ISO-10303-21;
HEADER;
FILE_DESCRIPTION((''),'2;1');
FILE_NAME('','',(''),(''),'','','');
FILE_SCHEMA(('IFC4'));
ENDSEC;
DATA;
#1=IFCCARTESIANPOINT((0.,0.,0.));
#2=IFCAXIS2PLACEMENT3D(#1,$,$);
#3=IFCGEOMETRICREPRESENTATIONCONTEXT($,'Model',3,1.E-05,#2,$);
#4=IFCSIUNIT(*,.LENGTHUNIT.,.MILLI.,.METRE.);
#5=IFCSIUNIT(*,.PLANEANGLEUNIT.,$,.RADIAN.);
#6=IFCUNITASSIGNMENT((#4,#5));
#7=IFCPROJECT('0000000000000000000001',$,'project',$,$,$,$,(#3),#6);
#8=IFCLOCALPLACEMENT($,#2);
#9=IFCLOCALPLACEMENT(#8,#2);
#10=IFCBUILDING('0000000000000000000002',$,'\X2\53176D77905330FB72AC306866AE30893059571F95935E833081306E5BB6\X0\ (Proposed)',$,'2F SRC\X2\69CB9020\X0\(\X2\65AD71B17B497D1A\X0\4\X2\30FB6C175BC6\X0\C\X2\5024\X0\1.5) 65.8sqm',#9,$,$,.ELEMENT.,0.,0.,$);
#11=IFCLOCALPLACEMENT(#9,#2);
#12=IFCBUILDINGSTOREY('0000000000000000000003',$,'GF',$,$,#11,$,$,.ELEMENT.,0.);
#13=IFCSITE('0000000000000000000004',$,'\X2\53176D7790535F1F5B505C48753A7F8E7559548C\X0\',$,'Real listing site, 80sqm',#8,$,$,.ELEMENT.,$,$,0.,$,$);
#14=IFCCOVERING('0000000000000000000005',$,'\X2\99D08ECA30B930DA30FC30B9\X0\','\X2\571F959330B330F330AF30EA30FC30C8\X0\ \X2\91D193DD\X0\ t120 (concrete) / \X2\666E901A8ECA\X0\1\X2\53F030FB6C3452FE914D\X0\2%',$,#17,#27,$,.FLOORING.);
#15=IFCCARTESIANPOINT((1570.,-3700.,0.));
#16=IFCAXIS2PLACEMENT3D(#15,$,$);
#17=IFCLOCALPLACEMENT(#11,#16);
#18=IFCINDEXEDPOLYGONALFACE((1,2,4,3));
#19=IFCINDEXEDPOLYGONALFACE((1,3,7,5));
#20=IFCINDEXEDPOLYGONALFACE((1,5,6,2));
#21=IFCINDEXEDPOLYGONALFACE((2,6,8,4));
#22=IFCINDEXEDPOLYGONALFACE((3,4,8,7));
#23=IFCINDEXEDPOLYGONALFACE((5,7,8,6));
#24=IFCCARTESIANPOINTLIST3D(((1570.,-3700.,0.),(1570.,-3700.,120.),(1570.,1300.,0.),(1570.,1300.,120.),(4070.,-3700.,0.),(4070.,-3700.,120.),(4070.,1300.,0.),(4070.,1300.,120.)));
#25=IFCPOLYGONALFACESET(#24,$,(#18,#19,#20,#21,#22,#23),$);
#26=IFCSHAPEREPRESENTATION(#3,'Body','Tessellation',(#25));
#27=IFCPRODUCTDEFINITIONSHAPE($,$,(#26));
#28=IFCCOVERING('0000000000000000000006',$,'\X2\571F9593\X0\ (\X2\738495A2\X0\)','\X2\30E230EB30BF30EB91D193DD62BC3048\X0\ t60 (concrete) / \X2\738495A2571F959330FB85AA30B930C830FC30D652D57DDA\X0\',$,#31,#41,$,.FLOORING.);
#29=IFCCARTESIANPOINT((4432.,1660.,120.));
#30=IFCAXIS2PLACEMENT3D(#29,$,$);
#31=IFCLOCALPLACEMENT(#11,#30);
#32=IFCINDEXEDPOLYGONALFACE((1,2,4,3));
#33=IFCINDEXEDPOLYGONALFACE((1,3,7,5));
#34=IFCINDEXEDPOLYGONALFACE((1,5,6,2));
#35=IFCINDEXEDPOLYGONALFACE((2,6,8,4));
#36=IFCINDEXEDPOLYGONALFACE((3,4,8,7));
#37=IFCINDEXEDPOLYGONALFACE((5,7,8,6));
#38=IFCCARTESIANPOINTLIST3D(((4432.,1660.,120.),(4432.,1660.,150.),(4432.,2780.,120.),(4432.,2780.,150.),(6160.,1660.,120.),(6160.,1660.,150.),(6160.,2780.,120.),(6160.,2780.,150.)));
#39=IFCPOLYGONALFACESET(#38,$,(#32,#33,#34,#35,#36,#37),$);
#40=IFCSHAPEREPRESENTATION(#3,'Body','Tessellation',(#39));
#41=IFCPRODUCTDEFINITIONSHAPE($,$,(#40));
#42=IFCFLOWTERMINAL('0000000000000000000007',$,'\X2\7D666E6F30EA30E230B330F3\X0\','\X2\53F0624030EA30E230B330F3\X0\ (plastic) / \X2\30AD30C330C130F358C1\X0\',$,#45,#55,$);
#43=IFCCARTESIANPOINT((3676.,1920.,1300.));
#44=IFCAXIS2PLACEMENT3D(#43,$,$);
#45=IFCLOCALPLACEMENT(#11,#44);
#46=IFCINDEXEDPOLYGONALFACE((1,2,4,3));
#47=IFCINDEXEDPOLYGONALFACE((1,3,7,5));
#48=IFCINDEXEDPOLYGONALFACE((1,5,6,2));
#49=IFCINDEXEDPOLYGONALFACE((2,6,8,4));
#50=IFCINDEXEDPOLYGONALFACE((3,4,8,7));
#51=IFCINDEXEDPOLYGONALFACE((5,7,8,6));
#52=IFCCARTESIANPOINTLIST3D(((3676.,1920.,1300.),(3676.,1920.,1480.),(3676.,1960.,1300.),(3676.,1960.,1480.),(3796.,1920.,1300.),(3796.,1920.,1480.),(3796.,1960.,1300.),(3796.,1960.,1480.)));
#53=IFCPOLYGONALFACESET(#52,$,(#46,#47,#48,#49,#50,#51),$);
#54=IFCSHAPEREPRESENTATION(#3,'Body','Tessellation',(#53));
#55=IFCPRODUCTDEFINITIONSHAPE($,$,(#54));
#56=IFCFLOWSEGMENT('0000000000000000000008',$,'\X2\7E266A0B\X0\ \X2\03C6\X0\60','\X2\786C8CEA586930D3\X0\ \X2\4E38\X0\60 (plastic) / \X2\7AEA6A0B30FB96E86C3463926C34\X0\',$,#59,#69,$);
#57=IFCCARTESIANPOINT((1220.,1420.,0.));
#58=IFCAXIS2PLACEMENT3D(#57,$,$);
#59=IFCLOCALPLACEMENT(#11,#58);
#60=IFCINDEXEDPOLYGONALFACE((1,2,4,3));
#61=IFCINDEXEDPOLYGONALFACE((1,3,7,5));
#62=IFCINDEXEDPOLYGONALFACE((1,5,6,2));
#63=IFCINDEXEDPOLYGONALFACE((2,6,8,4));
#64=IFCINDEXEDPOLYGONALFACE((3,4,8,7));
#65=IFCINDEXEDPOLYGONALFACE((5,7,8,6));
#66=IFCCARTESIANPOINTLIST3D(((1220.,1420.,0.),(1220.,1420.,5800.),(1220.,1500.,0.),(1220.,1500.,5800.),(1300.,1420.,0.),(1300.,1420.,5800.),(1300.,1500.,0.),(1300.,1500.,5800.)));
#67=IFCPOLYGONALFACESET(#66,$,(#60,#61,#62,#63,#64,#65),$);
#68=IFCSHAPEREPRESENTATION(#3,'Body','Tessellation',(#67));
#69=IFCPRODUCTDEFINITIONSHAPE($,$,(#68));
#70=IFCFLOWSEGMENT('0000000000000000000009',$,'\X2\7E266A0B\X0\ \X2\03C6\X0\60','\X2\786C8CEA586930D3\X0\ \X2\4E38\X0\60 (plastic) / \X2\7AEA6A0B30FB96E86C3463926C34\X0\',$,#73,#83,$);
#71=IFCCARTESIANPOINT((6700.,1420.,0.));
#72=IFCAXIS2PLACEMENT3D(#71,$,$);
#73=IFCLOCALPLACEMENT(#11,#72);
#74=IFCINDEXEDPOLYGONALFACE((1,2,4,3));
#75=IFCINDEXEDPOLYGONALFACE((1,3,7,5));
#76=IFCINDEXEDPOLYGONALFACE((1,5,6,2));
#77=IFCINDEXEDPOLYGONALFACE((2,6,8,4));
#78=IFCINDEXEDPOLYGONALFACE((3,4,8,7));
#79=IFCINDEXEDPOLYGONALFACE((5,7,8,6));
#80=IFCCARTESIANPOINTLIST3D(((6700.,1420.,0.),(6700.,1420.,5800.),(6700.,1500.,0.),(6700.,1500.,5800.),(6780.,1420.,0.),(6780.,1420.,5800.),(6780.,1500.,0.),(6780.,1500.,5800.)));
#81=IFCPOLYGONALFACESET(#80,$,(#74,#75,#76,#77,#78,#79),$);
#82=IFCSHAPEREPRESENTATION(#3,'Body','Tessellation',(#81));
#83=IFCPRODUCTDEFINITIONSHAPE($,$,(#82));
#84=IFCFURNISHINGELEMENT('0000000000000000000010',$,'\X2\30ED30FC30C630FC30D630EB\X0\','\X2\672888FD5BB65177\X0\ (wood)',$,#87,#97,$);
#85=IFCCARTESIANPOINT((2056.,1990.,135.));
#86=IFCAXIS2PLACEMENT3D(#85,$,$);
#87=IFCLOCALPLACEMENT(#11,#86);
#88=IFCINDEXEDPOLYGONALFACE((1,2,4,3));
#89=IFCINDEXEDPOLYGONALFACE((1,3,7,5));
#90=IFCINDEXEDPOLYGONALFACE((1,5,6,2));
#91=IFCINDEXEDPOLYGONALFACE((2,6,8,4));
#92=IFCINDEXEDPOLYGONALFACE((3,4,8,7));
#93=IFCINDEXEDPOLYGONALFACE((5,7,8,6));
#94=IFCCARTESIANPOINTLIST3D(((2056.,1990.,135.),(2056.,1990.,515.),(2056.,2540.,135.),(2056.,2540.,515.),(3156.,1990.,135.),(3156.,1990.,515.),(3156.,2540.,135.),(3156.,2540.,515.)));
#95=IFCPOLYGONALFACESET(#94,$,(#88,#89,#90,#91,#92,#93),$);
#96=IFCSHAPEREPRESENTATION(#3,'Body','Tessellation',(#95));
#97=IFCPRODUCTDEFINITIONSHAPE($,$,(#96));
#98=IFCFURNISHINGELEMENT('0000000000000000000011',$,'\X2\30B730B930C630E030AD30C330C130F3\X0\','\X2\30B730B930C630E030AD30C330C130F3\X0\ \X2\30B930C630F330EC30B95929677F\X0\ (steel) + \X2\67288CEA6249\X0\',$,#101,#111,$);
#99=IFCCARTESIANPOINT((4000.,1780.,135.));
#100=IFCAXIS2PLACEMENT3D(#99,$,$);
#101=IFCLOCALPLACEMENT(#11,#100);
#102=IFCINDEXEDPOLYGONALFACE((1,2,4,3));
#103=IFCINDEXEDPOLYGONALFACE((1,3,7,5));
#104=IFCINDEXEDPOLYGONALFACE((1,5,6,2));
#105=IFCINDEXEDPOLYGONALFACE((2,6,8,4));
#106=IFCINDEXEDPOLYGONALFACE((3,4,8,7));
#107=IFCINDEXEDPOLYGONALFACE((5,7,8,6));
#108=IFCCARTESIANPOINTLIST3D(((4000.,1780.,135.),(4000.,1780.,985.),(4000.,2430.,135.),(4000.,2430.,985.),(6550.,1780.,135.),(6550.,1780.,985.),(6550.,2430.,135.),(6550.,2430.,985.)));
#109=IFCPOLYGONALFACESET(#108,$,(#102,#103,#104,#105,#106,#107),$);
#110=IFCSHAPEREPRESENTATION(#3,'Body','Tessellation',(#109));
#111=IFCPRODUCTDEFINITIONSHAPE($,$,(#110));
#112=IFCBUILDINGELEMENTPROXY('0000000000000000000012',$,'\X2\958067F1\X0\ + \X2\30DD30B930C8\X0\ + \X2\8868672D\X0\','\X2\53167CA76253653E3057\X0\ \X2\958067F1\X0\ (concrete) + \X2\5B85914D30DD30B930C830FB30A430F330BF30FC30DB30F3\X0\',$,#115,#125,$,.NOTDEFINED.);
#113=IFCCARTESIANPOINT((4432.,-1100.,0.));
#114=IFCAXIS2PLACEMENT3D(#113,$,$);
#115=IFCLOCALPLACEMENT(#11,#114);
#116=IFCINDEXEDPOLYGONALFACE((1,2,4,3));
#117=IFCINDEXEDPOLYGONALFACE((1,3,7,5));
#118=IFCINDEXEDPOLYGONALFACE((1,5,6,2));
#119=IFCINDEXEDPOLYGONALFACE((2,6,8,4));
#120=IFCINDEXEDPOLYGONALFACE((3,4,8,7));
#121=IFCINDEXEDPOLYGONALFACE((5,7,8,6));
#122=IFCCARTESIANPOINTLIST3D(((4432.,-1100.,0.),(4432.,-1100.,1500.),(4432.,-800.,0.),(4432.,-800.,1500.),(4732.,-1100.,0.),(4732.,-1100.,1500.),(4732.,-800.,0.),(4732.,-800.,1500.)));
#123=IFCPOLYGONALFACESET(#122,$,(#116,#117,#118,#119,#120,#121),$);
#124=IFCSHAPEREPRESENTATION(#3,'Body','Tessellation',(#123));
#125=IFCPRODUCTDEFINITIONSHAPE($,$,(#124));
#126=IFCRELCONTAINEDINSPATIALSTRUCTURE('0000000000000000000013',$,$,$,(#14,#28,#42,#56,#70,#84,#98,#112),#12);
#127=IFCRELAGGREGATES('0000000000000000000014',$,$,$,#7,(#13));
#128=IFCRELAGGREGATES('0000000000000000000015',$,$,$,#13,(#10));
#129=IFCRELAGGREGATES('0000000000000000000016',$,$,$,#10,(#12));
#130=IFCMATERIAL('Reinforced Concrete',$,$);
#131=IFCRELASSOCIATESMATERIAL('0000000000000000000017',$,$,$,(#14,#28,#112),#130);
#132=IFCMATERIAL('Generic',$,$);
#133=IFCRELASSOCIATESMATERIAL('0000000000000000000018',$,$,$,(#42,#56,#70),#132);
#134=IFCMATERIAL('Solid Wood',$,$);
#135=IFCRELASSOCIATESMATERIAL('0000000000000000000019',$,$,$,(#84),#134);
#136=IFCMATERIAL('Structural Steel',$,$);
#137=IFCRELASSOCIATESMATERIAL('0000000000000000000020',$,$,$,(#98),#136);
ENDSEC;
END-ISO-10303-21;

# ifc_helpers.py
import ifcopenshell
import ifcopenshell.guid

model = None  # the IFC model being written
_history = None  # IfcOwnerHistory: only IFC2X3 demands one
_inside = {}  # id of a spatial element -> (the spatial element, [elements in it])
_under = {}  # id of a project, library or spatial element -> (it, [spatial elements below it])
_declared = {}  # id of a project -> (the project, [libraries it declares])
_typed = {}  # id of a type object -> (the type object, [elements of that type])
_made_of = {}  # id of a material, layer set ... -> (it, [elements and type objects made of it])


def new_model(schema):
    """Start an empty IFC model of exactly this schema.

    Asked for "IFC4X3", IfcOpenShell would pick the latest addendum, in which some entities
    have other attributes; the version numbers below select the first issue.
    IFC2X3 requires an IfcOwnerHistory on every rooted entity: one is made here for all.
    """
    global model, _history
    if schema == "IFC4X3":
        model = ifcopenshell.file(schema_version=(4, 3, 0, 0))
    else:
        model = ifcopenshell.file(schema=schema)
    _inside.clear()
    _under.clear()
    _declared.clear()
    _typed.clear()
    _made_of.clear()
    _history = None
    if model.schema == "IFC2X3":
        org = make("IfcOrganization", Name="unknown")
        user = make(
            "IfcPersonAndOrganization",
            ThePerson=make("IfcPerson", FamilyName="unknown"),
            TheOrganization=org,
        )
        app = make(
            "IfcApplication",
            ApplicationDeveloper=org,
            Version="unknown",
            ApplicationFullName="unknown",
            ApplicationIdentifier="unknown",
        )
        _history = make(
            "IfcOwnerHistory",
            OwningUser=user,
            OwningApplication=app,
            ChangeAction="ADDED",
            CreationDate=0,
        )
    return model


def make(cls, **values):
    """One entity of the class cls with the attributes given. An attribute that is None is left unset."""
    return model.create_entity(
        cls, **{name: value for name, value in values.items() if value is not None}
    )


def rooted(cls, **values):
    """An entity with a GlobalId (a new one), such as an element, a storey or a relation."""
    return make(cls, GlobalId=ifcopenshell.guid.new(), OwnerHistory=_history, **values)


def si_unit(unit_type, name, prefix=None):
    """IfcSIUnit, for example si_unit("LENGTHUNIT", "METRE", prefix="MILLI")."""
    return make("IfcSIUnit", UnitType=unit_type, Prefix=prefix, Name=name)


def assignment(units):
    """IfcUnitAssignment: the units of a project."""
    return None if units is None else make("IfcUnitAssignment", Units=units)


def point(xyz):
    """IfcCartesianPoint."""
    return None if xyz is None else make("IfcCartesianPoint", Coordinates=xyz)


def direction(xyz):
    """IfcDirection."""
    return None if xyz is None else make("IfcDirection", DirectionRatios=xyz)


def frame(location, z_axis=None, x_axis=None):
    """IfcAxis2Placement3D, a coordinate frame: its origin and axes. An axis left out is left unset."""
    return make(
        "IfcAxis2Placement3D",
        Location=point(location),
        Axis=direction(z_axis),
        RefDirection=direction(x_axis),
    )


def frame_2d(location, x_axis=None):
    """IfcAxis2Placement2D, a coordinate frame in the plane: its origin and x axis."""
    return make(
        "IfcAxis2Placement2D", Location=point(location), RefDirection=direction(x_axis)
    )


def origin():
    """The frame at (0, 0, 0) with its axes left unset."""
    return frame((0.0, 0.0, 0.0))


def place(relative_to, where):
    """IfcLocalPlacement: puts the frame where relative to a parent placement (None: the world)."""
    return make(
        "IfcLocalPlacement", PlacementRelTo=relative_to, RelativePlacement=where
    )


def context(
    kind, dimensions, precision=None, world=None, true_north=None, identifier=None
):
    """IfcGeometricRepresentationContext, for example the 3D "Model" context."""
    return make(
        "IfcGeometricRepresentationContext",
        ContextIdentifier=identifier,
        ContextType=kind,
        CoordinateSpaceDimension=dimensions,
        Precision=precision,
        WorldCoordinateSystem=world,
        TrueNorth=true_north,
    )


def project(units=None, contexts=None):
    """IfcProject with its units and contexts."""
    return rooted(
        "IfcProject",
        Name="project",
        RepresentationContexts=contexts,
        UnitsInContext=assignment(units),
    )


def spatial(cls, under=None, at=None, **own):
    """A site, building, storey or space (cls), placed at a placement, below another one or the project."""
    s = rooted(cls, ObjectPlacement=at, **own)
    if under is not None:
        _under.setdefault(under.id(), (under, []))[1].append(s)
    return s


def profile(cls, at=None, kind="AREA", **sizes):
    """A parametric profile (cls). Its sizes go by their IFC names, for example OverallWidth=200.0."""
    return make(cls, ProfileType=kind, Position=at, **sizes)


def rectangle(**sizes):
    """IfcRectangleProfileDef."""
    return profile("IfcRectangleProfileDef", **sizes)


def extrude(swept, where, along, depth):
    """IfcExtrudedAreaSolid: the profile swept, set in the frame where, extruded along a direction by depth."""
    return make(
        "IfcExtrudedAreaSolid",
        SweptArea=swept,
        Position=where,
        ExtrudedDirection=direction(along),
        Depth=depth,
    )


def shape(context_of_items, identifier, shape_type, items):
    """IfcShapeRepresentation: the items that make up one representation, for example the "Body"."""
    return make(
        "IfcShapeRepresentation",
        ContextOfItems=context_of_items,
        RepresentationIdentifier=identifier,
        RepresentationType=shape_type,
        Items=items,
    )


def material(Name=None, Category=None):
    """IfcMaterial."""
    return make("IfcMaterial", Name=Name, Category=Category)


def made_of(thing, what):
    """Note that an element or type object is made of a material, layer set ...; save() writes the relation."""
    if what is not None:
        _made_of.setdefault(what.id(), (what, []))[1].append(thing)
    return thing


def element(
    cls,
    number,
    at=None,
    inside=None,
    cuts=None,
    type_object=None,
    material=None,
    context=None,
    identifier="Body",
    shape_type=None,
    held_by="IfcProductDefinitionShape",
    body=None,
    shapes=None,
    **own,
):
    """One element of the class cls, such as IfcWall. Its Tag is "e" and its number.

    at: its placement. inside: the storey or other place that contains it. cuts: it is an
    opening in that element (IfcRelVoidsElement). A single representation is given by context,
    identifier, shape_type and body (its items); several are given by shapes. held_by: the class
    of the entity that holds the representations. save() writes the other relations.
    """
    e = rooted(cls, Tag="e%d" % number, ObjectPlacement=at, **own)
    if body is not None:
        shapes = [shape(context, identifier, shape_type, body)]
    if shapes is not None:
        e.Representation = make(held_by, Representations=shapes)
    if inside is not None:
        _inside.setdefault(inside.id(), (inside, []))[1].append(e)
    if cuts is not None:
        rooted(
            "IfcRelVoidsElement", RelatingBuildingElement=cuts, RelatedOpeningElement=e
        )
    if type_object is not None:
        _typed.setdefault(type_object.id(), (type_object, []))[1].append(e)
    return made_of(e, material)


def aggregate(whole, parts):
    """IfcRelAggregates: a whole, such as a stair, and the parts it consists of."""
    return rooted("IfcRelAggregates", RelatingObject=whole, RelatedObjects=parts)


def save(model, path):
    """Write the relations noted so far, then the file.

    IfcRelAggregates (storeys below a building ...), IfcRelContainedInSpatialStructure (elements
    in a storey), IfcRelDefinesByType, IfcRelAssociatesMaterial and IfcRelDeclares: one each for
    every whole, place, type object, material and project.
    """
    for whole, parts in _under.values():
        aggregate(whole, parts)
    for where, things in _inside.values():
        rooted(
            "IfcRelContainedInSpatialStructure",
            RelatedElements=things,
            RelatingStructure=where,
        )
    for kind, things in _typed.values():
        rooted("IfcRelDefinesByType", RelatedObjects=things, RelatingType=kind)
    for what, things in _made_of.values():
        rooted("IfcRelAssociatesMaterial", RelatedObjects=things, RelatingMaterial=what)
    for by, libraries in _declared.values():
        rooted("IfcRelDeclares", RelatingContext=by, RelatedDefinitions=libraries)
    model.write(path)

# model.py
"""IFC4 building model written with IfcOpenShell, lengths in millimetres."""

from ifc_helpers import new_model, si_unit, frame, frame_2d, origin, place, context, project, spatial, rectangle, extrude, material, element, save


model = new_model("IFC4")

# Units and contexts
model_context = context("Model", 3, precision=1e-05, world=origin())
ifc_project = project(units=[si_unit("LENGTHUNIT", "METRE", prefix="MILLI"), si_unit("PLANEANGLEUNIT", "RADIAN")], contexts=[model_context])

# Site, building, storey
site_placement = place(None, origin())
site = spatial("IfcSite", under=ifc_project, at=site_placement, Name="北海道弟子屈町美留和", ObjectType="Real listing site, 80sqm", CompositionType="ELEMENT", RefElevation=0.0)
building_placement = place(site_placement, origin())
building = spatial("IfcBuilding", under=site, at=building_placement, Name="北海道・犬と暮らす土間広めの家 (Proposed)", ObjectType="2F SRC構造(断熱等級4・気密C値1.5) 65.8sqm", CompositionType="ELEMENT", ElevationOfRefHeight=0.0, ElevationOfTerrain=0.0)
storey_placement = place(building_placement, origin())
storey = spatial("IfcBuildingStorey", under=building, at=storey_placement, Name="GF", CompositionType="ELEMENT", Elevation=0.0)

# Shared definitions
ifc_material_1 = material(Name="Solid Wood")

# Shared definitions
ifc_material_2 = material(Name="Reinforced Concrete")

# Coverings
ifc_material_3 = material(Name="Generic")
covering_1_placement = place(storey_placement, frame((1570.0, -3700.0, 0.0)))
element("IfcCovering", 1, at=covering_1_placement, inside=storey, material=ifc_material_2, Name="駐車スペース", Description="土間コンクリート 金鏝 t120 (concrete) / 普通車1台・水勾配2%", PredefinedType="FLOORING", context=model_context, shape_type="SweptSolid", body=[
    extrude(rectangle(XDim=2500.0, YDim=5000.0, at=frame_2d((1250.0, 2500.0))), frame((1570.0, -3700.0, 0.0)), (0.0, 0.0, 1.0), 120.0),
])
covering_2_placement = place(storey_placement, frame((4432.0, 1660.0, 120.0)))
element("IfcCovering", 2, at=covering_2_placement, inside=storey, material=ifc_material_2, Name="土間 (玄関)", Description="モルタル金鏝押え t60 (concrete) / 玄関土間・薪ストーブ動線", PredefinedType="FLOORING", context=model_context, shape_type="SweptSolid", body=[
    extrude(rectangle(XDim=1728.0, YDim=1120.0, at=frame_2d((864.0, 560.0))), frame((4432.0, 1660.0, 120.0)), (0.0, 0.0, 1.0), 30.0),
])

# Flow terminal
flow_terminal_placement = place(storey_placement, frame((3676.0, 1920.0, 1300.0)))
element("IfcFlowTerminal", 3, at=flow_terminal_placement, inside=storey, material=ifc_material_3, Name="給湯リモコン", Description="台所リモコン (plastic) / キッチン壁", context=model_context, shape_type="SweptSolid", body=[
    extrude(rectangle(XDim=120.0, YDim=40.0, at=frame_2d((60.0, 20.0))), frame((3676.0, 1920.0, 1300.0)), (0.0, 0.0, 1.0), 180.0),
])

# Flow segments
flow_segment_1_placement = place(storey_placement, frame((1220.0, 1420.0, 0.0)))
element("IfcFlowSegment", 4, at=flow_segment_1_placement, inside=storey, material=ifc_material_3, Name="縦樋 φ60", Description="硬質塩ビ 丸60 (plastic) / 竪樋・雨水排水", context=model_context, shape_type="SweptSolid", body=[
    extrude(rectangle(XDim=80.0, YDim=80.0, at=frame_2d((40.0, 40.0))), frame((1220.0, 1420.0, 0.0)), (0.0, 0.0, 1.0), 5800.0),
])
flow_segment_2_placement = place(storey_placement, frame((6700.0, 1420.0, 0.0)))
element("IfcFlowSegment", 5, at=flow_segment_2_placement, inside=storey, material=ifc_material_3, Name="縦樋 φ60", Description="硬質塩ビ 丸60 (plastic) / 竪樋・雨水排水", context=model_context, shape_type="SweptSolid", body=[
    extrude(rectangle(XDim=80.0, YDim=80.0, at=frame_2d((40.0, 40.0))), frame((6700.0, 1420.0, 0.0)), (0.0, 0.0, 1.0), 5800.0),
])

# Furnishing elements
furnishing_1_placement = place(storey_placement, frame((2056.0, 1990.0, 135.0)))
element("IfcFurnishingElement", 6, at=furnishing_1_placement, inside=storey, material=ifc_material_1, Name="ローテーブル", Description="木製家具 (wood)", context=model_context, shape_type="SweptSolid", body=[
    extrude(rectangle(XDim=1100.0, YDim=550.0, at=frame_2d((550.0, 275.0))), frame((2056.0, 1990.0, 135.0)), (0.0, 0.0, 1.0), 380.0),
])
ifc_material_4 = material(Name="Structural Steel")
furnishing_2_placement = place(storey_placement, frame((4000.0, 1780.0, 135.0)))
element("IfcFurnishingElement", 7, at=furnishing_2_placement, inside=storey, material=ifc_material_4, Name="システムキッチン", Description="システムキッチン ステンレス天板 (steel) + 木質扉", context=model_context, shape_type="SweptSolid", body=[
    extrude(rectangle(XDim=2550.0, YDim=650.0, at=frame_2d((1275.0, 325.0))), frame((4000.0, 1780.0, 135.0)), (0.0, 0.0, 1.0), 850.0),
])

# Building element proxy
proxy_placement = place(storey_placement, frame((4432.0, -1100.0, 0.0)))
element("IfcBuildingElementProxy", 8, at=proxy_placement, inside=storey, material=ifc_material_2, Name="門柱 + ポスト + 表札", Description="化粧打放し 門柱 (concrete) + 宅配ポスト・インターホン", PredefinedType="NOTDEFINED", context=model_context, shape_type="SweptSolid", body=[
    extrude(rectangle(XDim=300.0, YDim=300.0, at=frame_2d((150.0, 150.0))), frame((4432.0, -1100.0, 0.0)), (0.0, 0.0, 1.0), 1500.0),
])

save(model, "model.ifc")
